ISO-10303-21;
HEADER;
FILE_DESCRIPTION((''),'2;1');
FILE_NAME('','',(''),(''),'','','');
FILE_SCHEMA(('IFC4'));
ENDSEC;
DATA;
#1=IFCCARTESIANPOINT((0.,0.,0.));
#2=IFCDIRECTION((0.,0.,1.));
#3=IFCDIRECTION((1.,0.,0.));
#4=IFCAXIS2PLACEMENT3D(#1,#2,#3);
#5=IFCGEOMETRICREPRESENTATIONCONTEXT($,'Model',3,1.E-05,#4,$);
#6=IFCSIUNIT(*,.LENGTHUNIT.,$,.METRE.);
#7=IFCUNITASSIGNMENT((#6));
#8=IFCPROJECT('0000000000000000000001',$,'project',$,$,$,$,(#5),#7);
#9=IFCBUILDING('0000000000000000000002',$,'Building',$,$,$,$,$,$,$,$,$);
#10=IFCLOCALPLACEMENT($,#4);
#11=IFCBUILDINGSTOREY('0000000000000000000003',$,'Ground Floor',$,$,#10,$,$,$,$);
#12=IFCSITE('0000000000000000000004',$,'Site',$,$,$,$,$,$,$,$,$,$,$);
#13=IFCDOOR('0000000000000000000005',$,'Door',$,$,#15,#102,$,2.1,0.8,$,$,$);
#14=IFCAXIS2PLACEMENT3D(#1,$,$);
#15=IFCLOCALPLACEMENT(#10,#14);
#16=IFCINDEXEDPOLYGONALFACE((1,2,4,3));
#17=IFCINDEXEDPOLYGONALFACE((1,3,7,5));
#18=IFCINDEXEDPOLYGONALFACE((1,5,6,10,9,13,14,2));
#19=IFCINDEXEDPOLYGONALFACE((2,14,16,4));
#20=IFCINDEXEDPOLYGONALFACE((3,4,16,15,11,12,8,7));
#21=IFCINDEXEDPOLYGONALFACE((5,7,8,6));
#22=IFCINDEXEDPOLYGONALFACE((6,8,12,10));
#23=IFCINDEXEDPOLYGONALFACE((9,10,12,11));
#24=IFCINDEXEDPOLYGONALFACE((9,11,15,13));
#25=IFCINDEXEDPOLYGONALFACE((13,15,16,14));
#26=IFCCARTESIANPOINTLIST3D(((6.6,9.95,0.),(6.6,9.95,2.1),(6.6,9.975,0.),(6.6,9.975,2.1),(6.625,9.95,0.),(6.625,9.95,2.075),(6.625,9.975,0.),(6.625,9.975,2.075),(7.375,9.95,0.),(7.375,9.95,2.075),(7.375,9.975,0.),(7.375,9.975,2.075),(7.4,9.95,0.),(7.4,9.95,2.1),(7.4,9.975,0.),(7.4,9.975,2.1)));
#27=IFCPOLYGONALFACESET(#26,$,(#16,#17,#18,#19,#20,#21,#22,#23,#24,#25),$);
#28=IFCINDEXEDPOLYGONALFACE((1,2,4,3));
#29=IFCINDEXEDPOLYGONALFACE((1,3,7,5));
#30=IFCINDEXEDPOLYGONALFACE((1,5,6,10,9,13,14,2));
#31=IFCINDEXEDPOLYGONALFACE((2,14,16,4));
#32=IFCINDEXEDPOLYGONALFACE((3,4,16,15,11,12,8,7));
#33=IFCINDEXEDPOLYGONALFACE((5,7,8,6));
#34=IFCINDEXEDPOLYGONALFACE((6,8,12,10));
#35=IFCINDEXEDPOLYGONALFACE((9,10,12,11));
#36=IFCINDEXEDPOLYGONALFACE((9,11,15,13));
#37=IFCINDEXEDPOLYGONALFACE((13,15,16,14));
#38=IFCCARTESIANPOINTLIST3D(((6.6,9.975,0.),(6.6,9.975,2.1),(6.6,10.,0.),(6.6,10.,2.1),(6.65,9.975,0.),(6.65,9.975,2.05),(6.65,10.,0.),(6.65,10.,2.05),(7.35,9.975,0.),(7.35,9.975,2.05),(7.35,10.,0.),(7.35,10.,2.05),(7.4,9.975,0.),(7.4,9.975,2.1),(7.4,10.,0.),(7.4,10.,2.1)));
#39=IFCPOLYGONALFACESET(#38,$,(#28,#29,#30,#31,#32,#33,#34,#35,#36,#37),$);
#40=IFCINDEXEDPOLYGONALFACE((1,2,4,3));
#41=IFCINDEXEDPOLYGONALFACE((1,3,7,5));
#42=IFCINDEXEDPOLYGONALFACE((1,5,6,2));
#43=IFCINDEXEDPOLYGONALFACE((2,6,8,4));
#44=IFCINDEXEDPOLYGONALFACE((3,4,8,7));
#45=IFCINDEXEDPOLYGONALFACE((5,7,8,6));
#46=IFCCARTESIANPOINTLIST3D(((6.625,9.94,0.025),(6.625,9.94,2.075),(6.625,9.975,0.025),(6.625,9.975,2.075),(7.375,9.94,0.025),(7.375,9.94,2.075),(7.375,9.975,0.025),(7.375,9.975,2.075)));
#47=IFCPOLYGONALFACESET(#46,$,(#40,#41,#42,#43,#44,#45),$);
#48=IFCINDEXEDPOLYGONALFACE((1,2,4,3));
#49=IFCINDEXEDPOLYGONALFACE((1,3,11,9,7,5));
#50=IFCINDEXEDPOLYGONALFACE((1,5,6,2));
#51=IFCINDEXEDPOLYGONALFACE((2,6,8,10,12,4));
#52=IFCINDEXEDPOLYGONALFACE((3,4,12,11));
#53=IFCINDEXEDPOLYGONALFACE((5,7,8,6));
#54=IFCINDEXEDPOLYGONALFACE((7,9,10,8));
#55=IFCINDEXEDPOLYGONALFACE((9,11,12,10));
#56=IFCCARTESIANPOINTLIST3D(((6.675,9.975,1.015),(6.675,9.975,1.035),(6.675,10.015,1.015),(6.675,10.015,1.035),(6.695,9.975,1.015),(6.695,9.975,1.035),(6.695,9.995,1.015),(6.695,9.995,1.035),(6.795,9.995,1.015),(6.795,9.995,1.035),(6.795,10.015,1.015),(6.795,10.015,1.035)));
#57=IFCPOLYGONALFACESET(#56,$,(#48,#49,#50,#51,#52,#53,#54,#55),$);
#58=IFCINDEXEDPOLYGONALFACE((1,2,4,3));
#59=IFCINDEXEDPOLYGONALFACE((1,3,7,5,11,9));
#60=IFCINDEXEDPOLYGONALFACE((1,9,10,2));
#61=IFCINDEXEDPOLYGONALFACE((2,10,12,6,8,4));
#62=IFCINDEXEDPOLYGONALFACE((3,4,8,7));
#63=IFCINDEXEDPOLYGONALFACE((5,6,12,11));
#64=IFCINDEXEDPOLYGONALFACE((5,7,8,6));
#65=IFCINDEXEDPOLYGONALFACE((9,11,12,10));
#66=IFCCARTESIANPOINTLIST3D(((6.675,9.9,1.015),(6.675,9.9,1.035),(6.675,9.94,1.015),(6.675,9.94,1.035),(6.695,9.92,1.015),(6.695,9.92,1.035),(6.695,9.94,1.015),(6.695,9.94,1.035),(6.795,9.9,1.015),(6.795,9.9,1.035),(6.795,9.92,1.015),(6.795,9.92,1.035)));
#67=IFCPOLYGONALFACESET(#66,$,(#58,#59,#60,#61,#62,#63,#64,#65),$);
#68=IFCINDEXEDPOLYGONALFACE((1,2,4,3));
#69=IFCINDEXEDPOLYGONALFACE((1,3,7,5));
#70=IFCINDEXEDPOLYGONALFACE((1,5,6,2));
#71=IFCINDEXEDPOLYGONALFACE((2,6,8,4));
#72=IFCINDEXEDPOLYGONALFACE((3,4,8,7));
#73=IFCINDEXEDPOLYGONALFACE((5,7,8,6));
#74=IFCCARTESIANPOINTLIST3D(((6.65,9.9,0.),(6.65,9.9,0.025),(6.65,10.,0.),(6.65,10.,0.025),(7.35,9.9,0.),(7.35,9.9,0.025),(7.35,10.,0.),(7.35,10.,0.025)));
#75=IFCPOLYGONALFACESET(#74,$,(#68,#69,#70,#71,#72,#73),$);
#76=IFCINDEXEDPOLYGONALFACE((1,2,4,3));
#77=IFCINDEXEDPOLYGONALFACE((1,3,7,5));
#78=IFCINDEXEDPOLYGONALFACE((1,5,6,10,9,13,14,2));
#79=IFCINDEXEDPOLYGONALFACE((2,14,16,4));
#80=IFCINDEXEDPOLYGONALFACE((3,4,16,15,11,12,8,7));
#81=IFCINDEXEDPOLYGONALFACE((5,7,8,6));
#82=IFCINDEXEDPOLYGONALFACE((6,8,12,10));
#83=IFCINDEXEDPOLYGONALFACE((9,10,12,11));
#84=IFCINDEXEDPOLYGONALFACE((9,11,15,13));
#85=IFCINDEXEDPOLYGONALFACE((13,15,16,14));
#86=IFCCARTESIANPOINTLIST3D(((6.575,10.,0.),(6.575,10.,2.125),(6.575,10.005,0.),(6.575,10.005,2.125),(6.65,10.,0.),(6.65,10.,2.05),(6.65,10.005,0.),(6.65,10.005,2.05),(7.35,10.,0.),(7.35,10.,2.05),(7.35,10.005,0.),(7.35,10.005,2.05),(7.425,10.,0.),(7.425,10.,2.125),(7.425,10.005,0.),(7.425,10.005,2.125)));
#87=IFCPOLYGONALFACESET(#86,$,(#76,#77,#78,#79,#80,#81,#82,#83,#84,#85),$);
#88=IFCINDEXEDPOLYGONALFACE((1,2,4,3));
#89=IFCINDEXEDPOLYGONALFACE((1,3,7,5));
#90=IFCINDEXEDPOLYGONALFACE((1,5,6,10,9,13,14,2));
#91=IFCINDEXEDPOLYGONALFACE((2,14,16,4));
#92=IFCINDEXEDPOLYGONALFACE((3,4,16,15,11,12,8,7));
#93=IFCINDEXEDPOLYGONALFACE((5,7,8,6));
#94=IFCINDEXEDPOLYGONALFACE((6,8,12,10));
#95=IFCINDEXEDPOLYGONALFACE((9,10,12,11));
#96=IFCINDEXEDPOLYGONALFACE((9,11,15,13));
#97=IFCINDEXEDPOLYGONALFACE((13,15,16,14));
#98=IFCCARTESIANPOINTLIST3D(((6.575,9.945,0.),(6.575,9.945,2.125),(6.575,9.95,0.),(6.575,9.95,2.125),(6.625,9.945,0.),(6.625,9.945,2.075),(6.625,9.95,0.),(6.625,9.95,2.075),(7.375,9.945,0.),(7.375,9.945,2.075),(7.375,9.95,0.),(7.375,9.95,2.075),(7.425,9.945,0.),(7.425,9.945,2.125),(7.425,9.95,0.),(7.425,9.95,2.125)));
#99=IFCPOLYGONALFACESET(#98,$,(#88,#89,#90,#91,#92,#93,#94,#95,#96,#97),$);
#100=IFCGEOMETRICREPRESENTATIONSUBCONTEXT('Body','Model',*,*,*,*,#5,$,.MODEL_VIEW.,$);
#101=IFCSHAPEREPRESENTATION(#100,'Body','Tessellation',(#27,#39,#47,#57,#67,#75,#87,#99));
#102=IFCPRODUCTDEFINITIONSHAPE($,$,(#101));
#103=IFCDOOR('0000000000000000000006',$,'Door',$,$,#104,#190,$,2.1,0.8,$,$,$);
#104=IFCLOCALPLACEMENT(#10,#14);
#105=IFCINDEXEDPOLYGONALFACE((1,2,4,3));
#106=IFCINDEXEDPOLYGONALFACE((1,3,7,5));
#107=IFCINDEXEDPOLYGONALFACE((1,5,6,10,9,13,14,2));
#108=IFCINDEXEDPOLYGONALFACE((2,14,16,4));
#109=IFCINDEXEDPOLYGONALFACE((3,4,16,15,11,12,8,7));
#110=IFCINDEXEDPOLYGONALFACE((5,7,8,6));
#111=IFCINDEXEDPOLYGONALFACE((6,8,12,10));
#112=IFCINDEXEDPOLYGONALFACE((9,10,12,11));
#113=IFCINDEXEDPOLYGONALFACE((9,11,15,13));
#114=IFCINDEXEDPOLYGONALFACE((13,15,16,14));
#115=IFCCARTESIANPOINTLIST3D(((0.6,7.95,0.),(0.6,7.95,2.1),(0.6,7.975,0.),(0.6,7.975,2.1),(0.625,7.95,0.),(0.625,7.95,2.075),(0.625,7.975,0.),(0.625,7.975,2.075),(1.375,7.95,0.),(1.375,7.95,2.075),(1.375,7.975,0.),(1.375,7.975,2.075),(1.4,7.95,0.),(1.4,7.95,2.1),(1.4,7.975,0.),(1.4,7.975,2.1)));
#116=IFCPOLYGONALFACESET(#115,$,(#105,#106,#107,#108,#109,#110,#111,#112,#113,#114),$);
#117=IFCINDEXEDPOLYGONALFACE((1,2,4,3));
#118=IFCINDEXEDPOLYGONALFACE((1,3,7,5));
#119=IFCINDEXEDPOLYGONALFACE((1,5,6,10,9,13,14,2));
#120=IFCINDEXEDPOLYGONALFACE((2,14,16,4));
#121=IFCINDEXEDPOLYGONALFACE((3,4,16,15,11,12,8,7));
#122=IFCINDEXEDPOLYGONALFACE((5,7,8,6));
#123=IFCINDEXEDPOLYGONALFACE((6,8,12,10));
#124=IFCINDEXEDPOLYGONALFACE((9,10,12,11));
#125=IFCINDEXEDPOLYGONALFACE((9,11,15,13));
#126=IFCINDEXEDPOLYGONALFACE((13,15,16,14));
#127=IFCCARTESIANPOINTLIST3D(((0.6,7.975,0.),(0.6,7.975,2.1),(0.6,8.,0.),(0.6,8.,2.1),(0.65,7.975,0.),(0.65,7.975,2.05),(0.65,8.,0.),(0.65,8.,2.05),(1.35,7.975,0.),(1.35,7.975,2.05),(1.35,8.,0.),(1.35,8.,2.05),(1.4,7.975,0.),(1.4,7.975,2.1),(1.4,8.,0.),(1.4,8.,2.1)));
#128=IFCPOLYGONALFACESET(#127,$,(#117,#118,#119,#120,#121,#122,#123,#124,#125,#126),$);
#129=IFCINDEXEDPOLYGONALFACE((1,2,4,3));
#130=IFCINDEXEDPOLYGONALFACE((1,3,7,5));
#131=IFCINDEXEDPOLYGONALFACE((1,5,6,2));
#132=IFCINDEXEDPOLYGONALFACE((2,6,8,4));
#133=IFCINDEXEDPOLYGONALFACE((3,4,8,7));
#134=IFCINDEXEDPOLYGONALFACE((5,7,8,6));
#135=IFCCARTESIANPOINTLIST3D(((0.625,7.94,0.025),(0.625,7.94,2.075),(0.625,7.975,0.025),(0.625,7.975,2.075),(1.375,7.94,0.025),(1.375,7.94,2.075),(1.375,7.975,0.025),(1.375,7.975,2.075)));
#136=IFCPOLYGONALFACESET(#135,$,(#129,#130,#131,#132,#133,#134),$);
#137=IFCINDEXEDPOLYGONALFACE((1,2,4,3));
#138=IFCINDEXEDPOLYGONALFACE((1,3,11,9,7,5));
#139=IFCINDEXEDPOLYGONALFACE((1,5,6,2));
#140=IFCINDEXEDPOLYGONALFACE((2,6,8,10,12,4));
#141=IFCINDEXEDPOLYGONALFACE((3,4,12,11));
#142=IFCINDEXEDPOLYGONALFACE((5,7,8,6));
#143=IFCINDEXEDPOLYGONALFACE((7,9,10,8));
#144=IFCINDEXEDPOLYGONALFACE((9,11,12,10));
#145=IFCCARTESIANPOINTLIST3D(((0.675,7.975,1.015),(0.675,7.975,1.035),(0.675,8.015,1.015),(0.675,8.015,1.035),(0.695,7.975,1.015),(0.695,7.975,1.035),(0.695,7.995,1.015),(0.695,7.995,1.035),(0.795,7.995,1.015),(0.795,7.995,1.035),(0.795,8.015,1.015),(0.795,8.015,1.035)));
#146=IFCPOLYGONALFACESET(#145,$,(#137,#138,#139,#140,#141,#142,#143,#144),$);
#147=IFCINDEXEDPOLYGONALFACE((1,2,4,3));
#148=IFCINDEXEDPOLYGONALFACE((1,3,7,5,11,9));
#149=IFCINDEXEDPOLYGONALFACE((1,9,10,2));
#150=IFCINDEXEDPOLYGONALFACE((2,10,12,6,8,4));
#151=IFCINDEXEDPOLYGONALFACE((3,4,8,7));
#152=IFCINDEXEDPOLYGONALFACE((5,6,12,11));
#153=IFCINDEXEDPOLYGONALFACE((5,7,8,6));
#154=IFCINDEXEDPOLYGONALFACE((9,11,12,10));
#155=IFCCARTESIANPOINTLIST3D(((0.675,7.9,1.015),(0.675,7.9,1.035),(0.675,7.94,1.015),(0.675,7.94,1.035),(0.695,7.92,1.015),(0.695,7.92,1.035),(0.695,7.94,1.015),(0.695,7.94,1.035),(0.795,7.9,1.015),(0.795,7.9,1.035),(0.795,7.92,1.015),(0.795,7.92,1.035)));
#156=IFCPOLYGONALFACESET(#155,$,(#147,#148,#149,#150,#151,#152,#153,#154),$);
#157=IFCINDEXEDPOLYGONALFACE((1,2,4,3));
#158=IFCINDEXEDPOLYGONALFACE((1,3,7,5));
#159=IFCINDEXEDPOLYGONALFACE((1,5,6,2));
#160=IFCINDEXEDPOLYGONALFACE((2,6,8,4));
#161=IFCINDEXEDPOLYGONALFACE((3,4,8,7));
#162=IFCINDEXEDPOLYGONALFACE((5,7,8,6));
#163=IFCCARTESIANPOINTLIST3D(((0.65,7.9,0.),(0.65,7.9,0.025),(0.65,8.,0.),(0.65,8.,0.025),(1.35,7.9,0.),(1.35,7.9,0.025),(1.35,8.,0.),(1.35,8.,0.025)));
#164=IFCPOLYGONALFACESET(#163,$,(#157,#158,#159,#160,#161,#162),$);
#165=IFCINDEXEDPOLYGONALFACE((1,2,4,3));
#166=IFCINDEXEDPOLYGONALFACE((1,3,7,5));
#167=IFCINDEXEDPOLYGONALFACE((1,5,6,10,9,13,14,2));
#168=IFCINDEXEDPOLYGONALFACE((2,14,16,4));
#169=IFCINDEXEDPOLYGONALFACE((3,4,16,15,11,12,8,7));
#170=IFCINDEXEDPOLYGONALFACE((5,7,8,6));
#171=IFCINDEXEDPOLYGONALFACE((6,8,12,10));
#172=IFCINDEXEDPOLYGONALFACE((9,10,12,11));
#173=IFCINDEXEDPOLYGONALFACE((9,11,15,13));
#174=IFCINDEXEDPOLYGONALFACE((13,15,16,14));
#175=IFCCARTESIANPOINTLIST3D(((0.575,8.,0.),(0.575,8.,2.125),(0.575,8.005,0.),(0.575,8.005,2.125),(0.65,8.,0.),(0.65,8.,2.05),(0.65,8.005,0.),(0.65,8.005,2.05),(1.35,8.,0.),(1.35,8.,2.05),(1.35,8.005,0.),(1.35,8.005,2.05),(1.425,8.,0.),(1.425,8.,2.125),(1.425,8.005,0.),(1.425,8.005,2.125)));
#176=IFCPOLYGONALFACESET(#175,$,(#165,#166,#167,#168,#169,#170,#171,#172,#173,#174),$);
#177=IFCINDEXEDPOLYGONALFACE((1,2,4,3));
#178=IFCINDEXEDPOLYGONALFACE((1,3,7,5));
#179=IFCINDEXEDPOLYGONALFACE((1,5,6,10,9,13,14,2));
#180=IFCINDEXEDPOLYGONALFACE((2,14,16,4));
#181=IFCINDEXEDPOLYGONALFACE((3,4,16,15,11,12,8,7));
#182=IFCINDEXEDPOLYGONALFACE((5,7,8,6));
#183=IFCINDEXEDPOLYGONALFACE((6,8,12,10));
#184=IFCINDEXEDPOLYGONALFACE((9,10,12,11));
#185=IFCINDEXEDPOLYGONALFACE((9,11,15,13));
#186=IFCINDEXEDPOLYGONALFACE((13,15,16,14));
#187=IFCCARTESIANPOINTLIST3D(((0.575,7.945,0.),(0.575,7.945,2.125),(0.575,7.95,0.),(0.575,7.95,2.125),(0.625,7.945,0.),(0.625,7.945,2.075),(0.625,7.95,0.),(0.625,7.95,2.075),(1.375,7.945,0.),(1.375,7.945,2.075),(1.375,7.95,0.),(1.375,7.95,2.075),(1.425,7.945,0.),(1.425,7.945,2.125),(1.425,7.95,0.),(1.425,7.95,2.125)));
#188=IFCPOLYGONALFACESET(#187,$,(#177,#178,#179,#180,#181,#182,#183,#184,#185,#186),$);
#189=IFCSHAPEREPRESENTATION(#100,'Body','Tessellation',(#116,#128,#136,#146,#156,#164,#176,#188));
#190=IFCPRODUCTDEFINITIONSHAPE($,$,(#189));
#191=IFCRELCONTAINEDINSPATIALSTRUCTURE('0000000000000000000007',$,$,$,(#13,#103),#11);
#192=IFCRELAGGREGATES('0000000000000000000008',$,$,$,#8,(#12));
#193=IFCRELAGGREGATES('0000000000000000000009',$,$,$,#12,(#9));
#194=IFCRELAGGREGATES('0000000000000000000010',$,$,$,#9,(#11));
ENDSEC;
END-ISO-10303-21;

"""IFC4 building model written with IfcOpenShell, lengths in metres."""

from ifc_helpers import new_model, si_unit, frame, origin_with_axes, place, context, subcontext, project, spatial, line, indexed_curve, outline, extrude, element, save


model = new_model("IFC4")

# Units and contexts
model_context = context("Model", 3, precision=1e-05, world=origin_with_axes())
body_context = subcontext(model_context, "Body", "Model", "MODEL_VIEW")
ifc_project = project(units=[si_unit("LENGTHUNIT", "METRE")], contexts=[model_context])

# Site, building, storey
site = spatial("IfcSite", under=ifc_project, Name="Site")
building = spatial("IfcBuilding", under=site, Name="Building")
storey_placement = place(None, origin_with_axes())
storey = spatial("IfcBuildingStorey", under=building, at=storey_placement, Name="Ground Floor")

# Doors
door_1_placement = place(storey_placement, frame((7.4, 10.0, 0.0), z_axis=(0.0, 0.0, 1.0), x_axis=(-1.0, 0.0, 0.0)))
element("IfcDoor", 1, at=door_1_placement, inside=storey, Name="Door", OverallHeight=2.1, OverallWidth=0.8, context=body_context, shape_type="SweptSolid", body=[
    extrude(outline(indexed_curve([(0.0, 0.0), (0.0, 2.1), (0.8, 2.1), (0.8, 0.0), (0.775, 0.0), (0.775, 2.075), (0.025, 2.075), (0.025, 0.0)], segments=[line(1, 2, 3, 4, 5, 6, 7, 8, 1)])), frame((0.0, 0.025, 0.0), z_axis=(0.0, -1.0, 0.0), x_axis=(1.0, 0.0, 0.0)), (0.0, 0.0, -1.0), 0.025),
    extrude(outline(indexed_curve([(0.0, 0.0), (0.0, 2.1), (0.8, 2.1), (0.8, 0.0), (0.75, 0.0), (0.75, 2.05), (0.05, 2.05), (0.05, 0.0)], segments=[line(1, 2, 3, 4, 5, 6, 7, 8, 1)])), frame((0.0, 0.0, 0.0), z_axis=(0.0, -1.0, 0.0), x_axis=(1.0, 0.0, 0.0)), (0.0, 0.0, -1.0), 0.025),
    extrude(outline(indexed_curve([(0.0, 0.0), (0.75, 0.0), (0.75, 0.035), (0.0, 0.035)], segments=[line(1, 2, 3, 4, 1)])), frame((0.025, 0.025, 0.025), z_axis=(0.0, 0.0, 1.0), x_axis=(1.0, 0.0, 0.0)), (0.0, 0.0, 1.0), 2.05),
    extrude(outline(indexed_curve([(0.0, 0.0), (0.0, -0.04), (-0.12, -0.04), (-0.12, -0.02), (-0.02, -0.02), (-0.02, 0.0)], segments=[line(1, 2, 3, 4, 5, 6, 1)])), frame((0.725, 0.025, 1.015), z_axis=(0.0, 0.0, 1.0), x_axis=(1.0, 0.0, 0.0)), (0.0, 0.0, 1.0), 0.02),
    extrude(outline(indexed_curve([(0.0, 0.0), (0.0, 0.04), (-0.12, 0.04), (-0.12, 0.02), (-0.02, 0.02), (-0.02, 0.0)], segments=[line(1, 2, 3, 4, 5, 6, 1)])), frame((0.725, 0.06, 1.015), z_axis=(0.0, 0.0, 1.0), x_axis=(1.0, 0.0, 0.0)), (0.0, 0.0, 1.0), 0.02),
    extrude(outline(indexed_curve([(0.0, 0.0), (0.7, 0.0), (0.7, 0.1), (0.0, 0.1)], segments=[line(1, 2, 3, 4, 1)])), frame((0.05, 0.0, 0.0), z_axis=(0.0, 0.0, 1.0), x_axis=(1.0, 0.0, 0.0)), (0.0, 0.0, 1.0), 0.025),
    extrude(outline(indexed_curve([(0.0, 0.0), (0.0, 2.125), (0.85, 2.125), (0.85, 0.0), (0.775, 0.0), (0.775, 2.05), (0.075, 2.05), (0.075, 0.0)], segments=[line(1, 2, 3, 4, 5, 6, 7, 8, 1)])), frame((-0.025, -0.005, 0.0), z_axis=(0.0, -1.0, 0.0), x_axis=(1.0, 0.0, 0.0)), (0.0, 0.0, -1.0), 0.005),
    extrude(outline(indexed_curve([(0.0, 0.0), (0.0, 2.125), (0.85, 2.125), (0.85, 0.0), (0.8, 0.0), (0.8, 2.075), (0.05, 2.075), (0.05, 0.0)], segments=[line(1, 2, 3, 4, 5, 6, 7, 8, 1)])), frame((-0.025, 0.05, 0.0), z_axis=(0.0, -1.0, 0.0), x_axis=(1.0, 0.0, 0.0)), (0.0, 0.0, -1.0), 0.005),
])
door_2_placement = place(storey_placement, frame((1.4, 8.0, 0.0), z_axis=(0.0, 0.0, 1.0), x_axis=(-1.0, 0.0, 0.0)))
element("IfcDoor", 2, at=door_2_placement, inside=storey, Name="Door", OverallHeight=2.1, OverallWidth=0.8, context=body_context, shape_type="SweptSolid", body=[
    extrude(outline(indexed_curve([(0.0, 0.0), (0.0, 2.1), (0.8, 2.1), (0.8, 0.0), (0.775, 0.0), (0.775, 2.075), (0.025, 2.075), (0.025, 0.0)], segments=[line(1, 2, 3, 4, 5, 6, 7, 8, 1)])), frame((0.0, 0.025, 0.0), z_axis=(0.0, -1.0, 0.0), x_axis=(1.0, 0.0, 0.0)), (0.0, 0.0, -1.0), 0.025),
    extrude(outline(indexed_curve([(0.0, 0.0), (0.0, 2.1), (0.8, 2.1), (0.8, 0.0), (0.75, 0.0), (0.75, 2.05), (0.05, 2.05), (0.05, 0.0)], segments=[line(1, 2, 3, 4, 5, 6, 7, 8, 1)])), frame((0.0, 0.0, 0.0), z_axis=(0.0, -1.0, 0.0), x_axis=(1.0, 0.0, 0.0)), (0.0, 0.0, -1.0), 0.025),
    extrude(outline(indexed_curve([(0.0, 0.0), (0.75, 0.0), (0.75, 0.035), (0.0, 0.035)], segments=[line(1, 2, 3, 4, 1)])), frame((0.025, 0.025, 0.025), z_axis=(0.0, 0.0, 1.0), x_axis=(1.0, 0.0, 0.0)), (0.0, 0.0, 1.0), 2.05),
    extrude(outline(indexed_curve([(0.0, 0.0), (0.0, -0.04), (-0.12, -0.04), (-0.12, -0.02), (-0.02, -0.02), (-0.02, 0.0)], segments=[line(1, 2, 3, 4, 5, 6, 1)])), frame((0.725, 0.025, 1.015), z_axis=(0.0, 0.0, 1.0), x_axis=(1.0, 0.0, 0.0)), (0.0, 0.0, 1.0), 0.02),
    extrude(outline(indexed_curve([(0.0, 0.0), (0.0, 0.04), (-0.12, 0.04), (-0.12, 0.02), (-0.02, 0.02), (-0.02, 0.0)], segments=[line(1, 2, 3, 4, 5, 6, 1)])), frame((0.725, 0.06, 1.015), z_axis=(0.0, 0.0, 1.0), x_axis=(1.0, 0.0, 0.0)), (0.0, 0.0, 1.0), 0.02),
    extrude(outline(indexed_curve([(0.0, 0.0), (0.7, 0.0), (0.7, 0.1), (0.0, 0.1)], segments=[line(1, 2, 3, 4, 1)])), frame((0.05, 0.0, 0.0), z_axis=(0.0, 0.0, 1.0), x_axis=(1.0, 0.0, 0.0)), (0.0, 0.0, 1.0), 0.025),
    extrude(outline(indexed_curve([(0.0, 0.0), (0.0, 2.125), (0.85, 2.125), (0.85, 0.0), (0.775, 0.0), (0.775, 2.05), (0.075, 2.05), (0.075, 0.0)], segments=[line(1, 2, 3, 4, 5, 6, 7, 8, 1)])), frame((-0.025, -0.005, 0.0), z_axis=(0.0, -1.0, 0.0), x_axis=(1.0, 0.0, 0.0)), (0.0, 0.0, -1.0), 0.005),
    extrude(outline(indexed_curve([(0.0, 0.0), (0.0, 2.125), (0.85, 2.125), (0.85, 0.0), (0.8, 0.0), (0.8, 2.075), (0.05, 2.075), (0.05, 0.0)], segments=[line(1, 2, 3, 4, 5, 6, 7, 8, 1)])), frame((-0.025, 0.05, 0.0), z_axis=(0.0, -1.0, 0.0), x_axis=(1.0, 0.0, 0.0)), (0.0, 0.0, -1.0), 0.005),
])

save(model, "model.ifc")
